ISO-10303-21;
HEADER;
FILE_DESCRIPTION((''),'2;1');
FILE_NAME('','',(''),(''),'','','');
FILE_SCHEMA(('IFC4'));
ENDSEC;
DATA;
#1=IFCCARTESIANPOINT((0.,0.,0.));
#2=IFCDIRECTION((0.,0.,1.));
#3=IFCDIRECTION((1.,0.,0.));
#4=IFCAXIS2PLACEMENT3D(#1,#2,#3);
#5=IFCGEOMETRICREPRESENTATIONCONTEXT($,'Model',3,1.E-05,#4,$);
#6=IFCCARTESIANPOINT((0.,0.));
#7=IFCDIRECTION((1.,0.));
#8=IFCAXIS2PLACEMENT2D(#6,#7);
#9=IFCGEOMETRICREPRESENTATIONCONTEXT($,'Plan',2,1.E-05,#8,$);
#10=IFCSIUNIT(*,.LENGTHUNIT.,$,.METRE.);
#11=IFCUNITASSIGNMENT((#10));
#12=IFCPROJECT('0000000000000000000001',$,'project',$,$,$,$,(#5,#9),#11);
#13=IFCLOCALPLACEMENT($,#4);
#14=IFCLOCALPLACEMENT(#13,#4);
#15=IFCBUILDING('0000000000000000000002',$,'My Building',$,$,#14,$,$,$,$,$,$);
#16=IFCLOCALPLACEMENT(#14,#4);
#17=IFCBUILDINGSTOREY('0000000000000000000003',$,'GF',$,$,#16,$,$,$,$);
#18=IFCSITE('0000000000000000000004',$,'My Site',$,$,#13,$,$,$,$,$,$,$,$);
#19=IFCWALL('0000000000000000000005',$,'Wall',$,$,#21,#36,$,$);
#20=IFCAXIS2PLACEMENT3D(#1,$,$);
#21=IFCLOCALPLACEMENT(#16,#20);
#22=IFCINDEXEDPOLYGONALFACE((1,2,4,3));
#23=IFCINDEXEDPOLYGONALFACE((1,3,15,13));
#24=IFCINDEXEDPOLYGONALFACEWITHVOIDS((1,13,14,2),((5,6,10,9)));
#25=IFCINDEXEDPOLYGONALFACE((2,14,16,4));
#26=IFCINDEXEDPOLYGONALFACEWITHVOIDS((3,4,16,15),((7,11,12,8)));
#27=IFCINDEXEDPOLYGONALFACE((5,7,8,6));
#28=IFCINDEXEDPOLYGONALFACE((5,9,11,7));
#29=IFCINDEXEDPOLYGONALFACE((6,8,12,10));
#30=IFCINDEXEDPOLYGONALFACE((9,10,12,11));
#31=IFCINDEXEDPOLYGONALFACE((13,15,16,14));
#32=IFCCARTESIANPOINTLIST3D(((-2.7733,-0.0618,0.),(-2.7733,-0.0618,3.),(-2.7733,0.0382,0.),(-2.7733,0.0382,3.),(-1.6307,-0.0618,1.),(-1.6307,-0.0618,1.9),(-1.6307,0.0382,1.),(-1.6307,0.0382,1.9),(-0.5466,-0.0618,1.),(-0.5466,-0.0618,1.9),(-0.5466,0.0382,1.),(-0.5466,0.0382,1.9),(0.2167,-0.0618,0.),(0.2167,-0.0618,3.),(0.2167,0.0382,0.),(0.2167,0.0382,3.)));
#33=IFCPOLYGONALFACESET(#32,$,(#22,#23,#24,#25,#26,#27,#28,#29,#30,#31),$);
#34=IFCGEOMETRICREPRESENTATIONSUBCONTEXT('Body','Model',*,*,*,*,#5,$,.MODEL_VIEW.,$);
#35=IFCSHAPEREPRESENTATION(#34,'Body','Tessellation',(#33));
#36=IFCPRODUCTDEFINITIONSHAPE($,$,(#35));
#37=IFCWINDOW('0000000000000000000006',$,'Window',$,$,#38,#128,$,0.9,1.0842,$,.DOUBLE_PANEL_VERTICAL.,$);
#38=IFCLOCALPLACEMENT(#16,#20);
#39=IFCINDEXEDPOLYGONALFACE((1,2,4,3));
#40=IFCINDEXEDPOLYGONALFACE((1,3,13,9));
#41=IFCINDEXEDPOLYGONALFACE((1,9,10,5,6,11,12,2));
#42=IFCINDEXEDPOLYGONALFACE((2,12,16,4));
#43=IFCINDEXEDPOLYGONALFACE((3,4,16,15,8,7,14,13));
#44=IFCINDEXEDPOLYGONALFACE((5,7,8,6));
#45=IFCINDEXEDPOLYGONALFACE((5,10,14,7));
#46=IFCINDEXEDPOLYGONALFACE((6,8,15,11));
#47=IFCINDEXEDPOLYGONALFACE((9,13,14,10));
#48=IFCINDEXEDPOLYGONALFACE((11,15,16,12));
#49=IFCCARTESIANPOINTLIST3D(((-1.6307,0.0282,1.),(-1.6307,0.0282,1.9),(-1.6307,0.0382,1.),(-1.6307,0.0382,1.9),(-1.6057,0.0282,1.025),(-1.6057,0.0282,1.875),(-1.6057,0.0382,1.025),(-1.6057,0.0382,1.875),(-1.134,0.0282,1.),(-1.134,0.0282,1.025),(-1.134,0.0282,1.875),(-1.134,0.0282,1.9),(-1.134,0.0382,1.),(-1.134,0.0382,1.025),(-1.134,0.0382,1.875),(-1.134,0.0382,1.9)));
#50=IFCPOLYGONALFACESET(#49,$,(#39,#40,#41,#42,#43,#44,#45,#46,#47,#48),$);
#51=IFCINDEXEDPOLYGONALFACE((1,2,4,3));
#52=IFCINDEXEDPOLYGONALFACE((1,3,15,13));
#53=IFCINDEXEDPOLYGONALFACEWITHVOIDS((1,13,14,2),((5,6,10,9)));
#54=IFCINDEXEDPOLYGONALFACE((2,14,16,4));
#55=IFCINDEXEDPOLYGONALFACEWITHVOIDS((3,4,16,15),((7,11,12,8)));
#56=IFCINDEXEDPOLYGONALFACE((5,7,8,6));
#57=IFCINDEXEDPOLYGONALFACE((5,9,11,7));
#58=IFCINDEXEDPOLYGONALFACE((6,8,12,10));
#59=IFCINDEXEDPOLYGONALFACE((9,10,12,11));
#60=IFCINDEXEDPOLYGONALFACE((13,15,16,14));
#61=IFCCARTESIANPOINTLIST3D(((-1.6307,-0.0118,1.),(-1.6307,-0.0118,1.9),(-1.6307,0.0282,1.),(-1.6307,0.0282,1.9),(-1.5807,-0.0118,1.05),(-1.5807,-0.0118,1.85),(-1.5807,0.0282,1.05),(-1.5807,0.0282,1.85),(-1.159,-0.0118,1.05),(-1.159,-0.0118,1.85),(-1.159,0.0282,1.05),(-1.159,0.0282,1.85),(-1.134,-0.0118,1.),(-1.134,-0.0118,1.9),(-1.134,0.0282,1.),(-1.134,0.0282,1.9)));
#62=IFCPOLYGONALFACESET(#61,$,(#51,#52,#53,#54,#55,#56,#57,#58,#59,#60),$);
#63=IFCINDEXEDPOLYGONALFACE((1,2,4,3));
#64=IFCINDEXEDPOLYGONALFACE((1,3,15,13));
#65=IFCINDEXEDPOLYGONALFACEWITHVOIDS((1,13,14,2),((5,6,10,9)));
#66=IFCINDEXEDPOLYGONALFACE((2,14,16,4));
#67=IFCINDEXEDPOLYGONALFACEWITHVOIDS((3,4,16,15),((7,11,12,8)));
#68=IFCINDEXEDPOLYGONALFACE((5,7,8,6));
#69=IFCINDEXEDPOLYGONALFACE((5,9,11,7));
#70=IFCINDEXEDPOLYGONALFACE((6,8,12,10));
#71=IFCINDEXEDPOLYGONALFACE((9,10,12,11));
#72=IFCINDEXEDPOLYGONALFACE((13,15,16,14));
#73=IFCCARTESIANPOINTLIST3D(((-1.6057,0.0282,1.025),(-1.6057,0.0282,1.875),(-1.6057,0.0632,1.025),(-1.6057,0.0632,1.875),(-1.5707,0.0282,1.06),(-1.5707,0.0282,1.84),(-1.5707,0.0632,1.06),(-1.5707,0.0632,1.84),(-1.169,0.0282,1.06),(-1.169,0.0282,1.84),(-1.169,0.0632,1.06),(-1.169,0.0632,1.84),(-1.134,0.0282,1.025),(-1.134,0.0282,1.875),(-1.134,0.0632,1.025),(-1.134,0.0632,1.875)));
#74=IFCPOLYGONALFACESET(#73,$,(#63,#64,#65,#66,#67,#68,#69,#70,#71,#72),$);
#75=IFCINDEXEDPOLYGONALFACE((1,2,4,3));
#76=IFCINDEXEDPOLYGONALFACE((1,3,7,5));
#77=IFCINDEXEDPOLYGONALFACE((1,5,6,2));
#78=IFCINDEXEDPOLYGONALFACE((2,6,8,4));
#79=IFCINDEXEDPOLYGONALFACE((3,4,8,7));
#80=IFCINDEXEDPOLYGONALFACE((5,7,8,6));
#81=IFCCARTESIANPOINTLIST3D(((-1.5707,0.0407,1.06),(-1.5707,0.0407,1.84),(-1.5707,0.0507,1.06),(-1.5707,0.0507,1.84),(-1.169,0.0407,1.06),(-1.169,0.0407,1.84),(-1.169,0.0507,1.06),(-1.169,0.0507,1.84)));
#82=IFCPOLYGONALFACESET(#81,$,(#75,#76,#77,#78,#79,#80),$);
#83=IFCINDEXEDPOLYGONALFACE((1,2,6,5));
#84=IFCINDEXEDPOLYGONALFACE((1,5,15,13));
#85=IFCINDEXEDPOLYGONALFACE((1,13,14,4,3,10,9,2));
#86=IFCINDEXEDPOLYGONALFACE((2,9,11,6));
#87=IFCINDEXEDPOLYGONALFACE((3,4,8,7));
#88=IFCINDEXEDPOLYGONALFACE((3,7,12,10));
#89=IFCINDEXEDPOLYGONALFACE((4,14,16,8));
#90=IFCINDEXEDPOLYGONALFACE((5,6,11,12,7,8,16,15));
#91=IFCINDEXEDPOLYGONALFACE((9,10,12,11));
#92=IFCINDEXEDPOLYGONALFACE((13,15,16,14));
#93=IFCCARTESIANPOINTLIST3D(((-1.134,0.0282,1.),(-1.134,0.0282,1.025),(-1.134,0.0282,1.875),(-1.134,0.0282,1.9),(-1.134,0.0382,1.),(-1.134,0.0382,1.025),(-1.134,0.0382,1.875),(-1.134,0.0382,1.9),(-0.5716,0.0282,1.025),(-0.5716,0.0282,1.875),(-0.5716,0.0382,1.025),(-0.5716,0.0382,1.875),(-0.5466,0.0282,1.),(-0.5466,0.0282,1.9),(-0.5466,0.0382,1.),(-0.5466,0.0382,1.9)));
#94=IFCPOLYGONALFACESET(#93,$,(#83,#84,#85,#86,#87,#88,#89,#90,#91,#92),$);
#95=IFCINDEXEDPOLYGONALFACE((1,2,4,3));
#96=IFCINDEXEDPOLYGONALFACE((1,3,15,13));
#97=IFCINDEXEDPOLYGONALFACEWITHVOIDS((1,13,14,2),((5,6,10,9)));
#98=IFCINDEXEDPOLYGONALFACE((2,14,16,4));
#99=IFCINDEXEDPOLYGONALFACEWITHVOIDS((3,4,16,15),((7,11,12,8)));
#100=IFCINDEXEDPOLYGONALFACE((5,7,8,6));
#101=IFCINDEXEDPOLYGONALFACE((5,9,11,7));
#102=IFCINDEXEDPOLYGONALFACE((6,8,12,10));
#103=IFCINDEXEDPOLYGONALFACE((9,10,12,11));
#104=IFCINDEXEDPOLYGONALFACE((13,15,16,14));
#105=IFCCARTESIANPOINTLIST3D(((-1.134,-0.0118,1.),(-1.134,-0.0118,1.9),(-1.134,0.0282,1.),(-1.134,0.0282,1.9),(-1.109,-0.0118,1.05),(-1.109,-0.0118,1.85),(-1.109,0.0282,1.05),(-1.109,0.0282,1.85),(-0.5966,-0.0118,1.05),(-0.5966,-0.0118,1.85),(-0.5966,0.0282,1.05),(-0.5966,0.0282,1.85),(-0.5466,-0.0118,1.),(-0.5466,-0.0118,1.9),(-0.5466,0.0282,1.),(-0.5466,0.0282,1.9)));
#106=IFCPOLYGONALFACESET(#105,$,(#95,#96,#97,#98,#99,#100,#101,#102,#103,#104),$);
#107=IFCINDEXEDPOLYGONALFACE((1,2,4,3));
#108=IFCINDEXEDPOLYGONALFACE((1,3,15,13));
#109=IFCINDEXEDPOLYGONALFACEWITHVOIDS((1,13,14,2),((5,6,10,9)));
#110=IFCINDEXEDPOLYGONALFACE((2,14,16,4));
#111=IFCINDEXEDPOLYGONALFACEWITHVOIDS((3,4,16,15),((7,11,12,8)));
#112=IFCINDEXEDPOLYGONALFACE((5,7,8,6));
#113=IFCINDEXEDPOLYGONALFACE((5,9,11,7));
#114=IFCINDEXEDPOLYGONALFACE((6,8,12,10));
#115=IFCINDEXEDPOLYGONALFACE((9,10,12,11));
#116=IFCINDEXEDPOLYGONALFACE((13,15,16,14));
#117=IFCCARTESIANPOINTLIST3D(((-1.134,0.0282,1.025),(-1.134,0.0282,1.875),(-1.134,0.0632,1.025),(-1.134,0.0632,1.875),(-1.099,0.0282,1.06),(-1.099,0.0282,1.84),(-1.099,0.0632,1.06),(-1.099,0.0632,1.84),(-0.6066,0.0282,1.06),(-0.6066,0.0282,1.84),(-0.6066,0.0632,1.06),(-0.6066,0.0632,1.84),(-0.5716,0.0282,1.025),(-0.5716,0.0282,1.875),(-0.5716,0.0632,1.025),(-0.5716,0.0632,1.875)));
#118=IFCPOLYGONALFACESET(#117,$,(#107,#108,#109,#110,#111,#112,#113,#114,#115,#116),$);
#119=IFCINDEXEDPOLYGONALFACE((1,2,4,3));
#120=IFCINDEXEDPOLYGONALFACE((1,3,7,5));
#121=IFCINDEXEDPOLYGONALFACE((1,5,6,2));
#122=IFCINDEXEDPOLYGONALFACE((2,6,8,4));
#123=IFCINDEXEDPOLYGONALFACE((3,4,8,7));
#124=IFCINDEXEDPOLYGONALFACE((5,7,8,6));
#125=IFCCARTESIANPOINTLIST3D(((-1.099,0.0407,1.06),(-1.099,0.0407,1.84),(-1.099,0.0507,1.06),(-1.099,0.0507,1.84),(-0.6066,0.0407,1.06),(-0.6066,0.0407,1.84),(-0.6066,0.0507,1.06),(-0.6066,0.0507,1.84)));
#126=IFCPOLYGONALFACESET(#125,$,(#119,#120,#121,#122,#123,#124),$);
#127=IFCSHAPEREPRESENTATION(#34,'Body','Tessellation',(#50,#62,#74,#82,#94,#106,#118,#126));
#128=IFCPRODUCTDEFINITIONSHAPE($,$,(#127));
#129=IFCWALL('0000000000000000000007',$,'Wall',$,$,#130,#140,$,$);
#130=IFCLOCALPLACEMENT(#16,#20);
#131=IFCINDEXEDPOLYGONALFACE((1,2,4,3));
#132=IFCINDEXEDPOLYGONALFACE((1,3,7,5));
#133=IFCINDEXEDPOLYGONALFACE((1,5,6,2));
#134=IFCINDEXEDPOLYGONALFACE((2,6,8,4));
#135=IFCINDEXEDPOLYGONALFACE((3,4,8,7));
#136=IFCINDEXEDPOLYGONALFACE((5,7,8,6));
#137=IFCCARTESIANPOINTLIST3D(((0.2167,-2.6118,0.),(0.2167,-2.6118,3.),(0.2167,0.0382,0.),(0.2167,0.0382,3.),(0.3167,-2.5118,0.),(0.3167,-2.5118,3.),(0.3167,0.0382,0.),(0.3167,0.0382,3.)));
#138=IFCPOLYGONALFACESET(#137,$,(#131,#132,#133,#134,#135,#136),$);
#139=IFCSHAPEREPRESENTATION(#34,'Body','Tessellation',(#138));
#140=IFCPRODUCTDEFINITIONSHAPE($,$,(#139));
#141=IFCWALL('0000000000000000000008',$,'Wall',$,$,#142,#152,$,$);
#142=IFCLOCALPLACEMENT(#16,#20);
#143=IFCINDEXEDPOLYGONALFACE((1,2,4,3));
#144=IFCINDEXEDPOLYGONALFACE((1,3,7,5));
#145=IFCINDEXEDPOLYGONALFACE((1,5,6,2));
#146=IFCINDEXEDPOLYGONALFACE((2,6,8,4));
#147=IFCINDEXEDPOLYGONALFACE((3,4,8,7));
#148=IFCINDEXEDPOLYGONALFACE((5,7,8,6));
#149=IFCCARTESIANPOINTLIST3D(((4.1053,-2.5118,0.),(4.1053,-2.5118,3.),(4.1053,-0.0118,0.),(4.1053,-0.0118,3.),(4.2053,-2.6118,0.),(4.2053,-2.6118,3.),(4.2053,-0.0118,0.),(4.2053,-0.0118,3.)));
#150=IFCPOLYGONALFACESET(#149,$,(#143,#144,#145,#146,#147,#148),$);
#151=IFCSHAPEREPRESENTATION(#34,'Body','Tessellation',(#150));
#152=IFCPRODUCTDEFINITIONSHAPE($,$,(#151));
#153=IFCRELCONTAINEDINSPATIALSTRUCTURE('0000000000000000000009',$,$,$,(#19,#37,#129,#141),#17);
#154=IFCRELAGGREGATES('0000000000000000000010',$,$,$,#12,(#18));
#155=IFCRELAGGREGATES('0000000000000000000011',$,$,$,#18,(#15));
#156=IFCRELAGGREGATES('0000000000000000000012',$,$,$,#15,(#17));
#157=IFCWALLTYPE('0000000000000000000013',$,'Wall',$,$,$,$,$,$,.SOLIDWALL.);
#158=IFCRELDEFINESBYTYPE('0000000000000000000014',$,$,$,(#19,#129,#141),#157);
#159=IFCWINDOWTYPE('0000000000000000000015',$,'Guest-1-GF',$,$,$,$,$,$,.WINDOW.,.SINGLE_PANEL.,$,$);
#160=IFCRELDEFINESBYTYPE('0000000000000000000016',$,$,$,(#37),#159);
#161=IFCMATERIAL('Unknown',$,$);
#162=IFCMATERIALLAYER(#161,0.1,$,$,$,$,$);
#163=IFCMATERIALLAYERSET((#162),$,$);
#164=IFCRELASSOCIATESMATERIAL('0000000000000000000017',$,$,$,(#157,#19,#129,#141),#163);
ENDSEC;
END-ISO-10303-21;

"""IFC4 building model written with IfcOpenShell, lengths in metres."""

from ifc_helpers import new_model, entity, si_unit, frame, origin_with_axes, origin_2d_with_axis, place, context, subcontext, project, spatial, line, indexed_curve, outline, extrude, shape, source, transform, mapped, material, layer, layer_set, layer_usage, type_object, type_shapes, element, fill, save


model = new_model("IFC4")

# Units and contexts
model_context = context("Model", 3, precision=1e-05, world=origin_with_axes())
plan_context = context("Plan", 2, precision=1e-05, world=origin_2d_with_axis())
body_context_1 = subcontext(model_context, "Body", "Model", "MODEL_VIEW")
body_context_2 = subcontext(plan_context, "Body", "Plan", "PLAN_VIEW")
ifc_project = project(units=[si_unit("LENGTHUNIT", "METRE")], contexts=[model_context, plan_context])

# Site, building, storey
site_placement = place(None, origin_with_axes())
site = spatial("IfcSite", under=ifc_project, at=site_placement, Name="My Site")
building_placement = place(site_placement, origin_with_axes())
building = spatial("IfcBuilding", under=site, at=building_placement, Name="My Building")
storey_placement = place(building_placement, origin_with_axes())
storey = spatial("IfcBuildingStorey", under=building, at=storey_placement, Name="GF")

# Shared definitions
ifc_material_1 = material(Name="Unknown")

# Wall, opening, window
ifc_layer_1 = layer(ifc_material_1, 0.1)
ifc_layer_set_1 = layer_set([ifc_layer_1])
ifc_layer_usage_1 = layer_usage(ifc_layer_set_1, "AXIS2", "POSITIVE", 0.0)
wall_type = type_object("IfcWallType", Name="Wall", PredefinedType="SOLIDWALL", material=ifc_layer_set_1)
wall_1_placement = place(storey_placement, frame((0.2167, 0.0382, 0.0), z_axis=(0.0, 0.0, 1.0), x_axis=(-1.0, 0.0, 0.0)))
wall_1 = element("IfcWall", 1, at=wall_1_placement, inside=storey, type_object=wall_type, material=ifc_layer_usage_1, Name="Wall", context=body_context_1, shape_type="SweptSolid", body=[
    extrude(outline(indexed_curve([(0.0, 0.0), (0.0, 0.1), (2.99, 0.1), (2.99, 0.0)], segments=[line(1, 2, 3, 4, 1)])), origin_with_axes(), (0.0, 0.0, 1.0), 3.0),
])
shared_shape_1 = source(origin_with_axes(), body_context_1, "Body", "SweptSolid", [
    extrude(outline(indexed_curve([(0.0, 0.0), (1.0842, 0.0), (1.0842, 0.9), (0.0, 0.9)], segments=[line(1, 2, 3, 4, 1)])), frame((0.0, -0.6, 0.0), z_axis=(0.0, -1.0, 0.0), x_axis=(1.0, 0.0, 0.0)), (0.0, 0.0, -1.0), 1.2),
])
opening_1_placement = place(wall_1_placement, frame((1.8474, 0.1, 1.0), z_axis=(0.0, 0.0, 1.0), x_axis=(-1.0, 0.0, 0.0)))
opening_1 = element("IfcOpeningElement", 2, at=opening_1_placement, cuts=wall_1, PredefinedType="OPENING", context=body_context_1, shape_type="MappedRepresentation", body=[
    mapped(shared_shape_1, transform((0.0, 0.0, 0.0), x_axis=(1.0, 0.0, 0.0), y_axis=(0.0, 1.0, 0.0), z_axis=(0.0, 0.0, 1.0), scale=1.0)),
])
window_type_1 = type_object("IfcWindowType", Name="Guest-1-GF", PartitioningType="SINGLE_PANEL", PredefinedType="WINDOW")
shared_shape_2 = source(origin_with_axes(), body_context_1, "Body", "SweptSolid", [
    extrude(outline(indexed_curve([(0.4967, 0.0), (0.0, 0.0), (0.0, 0.9), (0.4967, 0.9), (0.4967, 0.875), (0.025, 0.875), (0.025, 0.025), (0.4967, 0.025)], segments=[line(1, 2, 3, 4, 5, 6, 7, 8, 1)])), frame((0.0, 0.09, 0.0), z_axis=(0.0, -1.0, 0.0), x_axis=(1.0, 0.0, 0.0)), (0.0, 0.0, -1.0), 0.01),
    extrude(outline(indexed_curve([(0.0, 0.0), (0.4967, 0.0), (0.4967, 0.9), (0.0, 0.9)], segments=[line(1, 2, 3, 4, 1)]), holes=[indexed_curve([(0.05, 0.05), (0.4717, 0.05), (0.4717, 0.85), (0.05, 0.85)], segments=[line(1, 2, 3, 4, 1)])]), frame((0.0, 0.05, 0.0), z_axis=(0.0, -1.0, 0.0), x_axis=(1.0, 0.0, 0.0)), (0.0, 0.0, -1.0), 0.04),
    extrude(outline(indexed_curve([(0.0, 0.0), (0.4717, 0.0), (0.4717, 0.85), (0.0, 0.85)], segments=[line(1, 2, 3, 4, 1)]), holes=[indexed_curve([(0.035, 0.035), (0.4367, 0.035), (0.4367, 0.815), (0.035, 0.815)], segments=[line(1, 2, 3, 4, 1)])]), frame((0.025, 0.09, 0.025), z_axis=(0.0, -1.0, 0.0), x_axis=(1.0, 0.0, 0.0)), (0.0, 0.0, -1.0), 0.035),
    extrude(outline(indexed_curve([(0.035, 0.035), (0.4367, 0.035), (0.4367, 0.815), (0.035, 0.815)], segments=[line(1, 2, 3, 4, 1)])), frame((0.025, 0.1025, 0.025), z_axis=(0.0, -1.0, 0.0), x_axis=(1.0, 0.0, 0.0)), (0.0, 0.0, -1.0), 0.01),
    extrude(outline(indexed_curve([(0.0, 0.9), (0.5874, 0.9), (0.5874, 0.0), (0.0, 0.0), (0.0, 0.025), (0.5624, 0.025), (0.5624, 0.875), (0.0, 0.875)], segments=[line(1, 2, 3, 4, 5, 6, 7, 8, 1)])), frame((0.4967, 0.09, 0.0), z_axis=(0.0, -1.0, 0.0), x_axis=(1.0, 0.0, 0.0)), (0.0, 0.0, -1.0), 0.01),
    extrude(outline(indexed_curve([(0.0, 0.0), (0.5874, 0.0), (0.5874, 0.9), (0.0, 0.9)], segments=[line(1, 2, 3, 4, 1)]), holes=[indexed_curve([(0.025, 0.05), (0.5374, 0.05), (0.5374, 0.85), (0.025, 0.85)], segments=[line(1, 2, 3, 4, 1)])]), frame((0.4967, 0.05, 0.0), z_axis=(0.0, -1.0, 0.0), x_axis=(1.0, 0.0, 0.0)), (0.0, 0.0, -1.0), 0.04),
    extrude(outline(indexed_curve([(0.0, 0.0), (0.5624, 0.0), (0.5624, 0.85), (0.0, 0.85)], segments=[line(1, 2, 3, 4, 1)]), holes=[indexed_curve([(0.035, 0.035), (0.5274, 0.035), (0.5274, 0.815), (0.035, 0.815)], segments=[line(1, 2, 3, 4, 1)])]), frame((0.4967, 0.09, 0.025), z_axis=(0.0, -1.0, 0.0), x_axis=(1.0, 0.0, 0.0)), (0.0, 0.0, -1.0), 0.035),
    extrude(outline(indexed_curve([(0.035, 0.035), (0.5274, 0.035), (0.5274, 0.815), (0.035, 0.815)], segments=[line(1, 2, 3, 4, 1)])), frame((0.4967, 0.1025, 0.025), z_axis=(0.0, -1.0, 0.0), x_axis=(1.0, 0.0, 0.0)), (0.0, 0.0, -1.0), 0.01),
])
shared_shape_3 = source(origin_with_axes(), body_context_2, "Body", "Curve2D", [
    entity("IfcIndexedPolyCurve", entity("IfcCartesianPointList2D", [[0.05, 0.05], [0.4717, 0.05]])),
    entity("IfcIndexedPolyCurve", entity("IfcCartesianPointList2D", [[0.0, 0.1], [0.025, 0.1], [0.025, 0.09], [0.05, 0.09], [0.05, 0.05], [0.0, 0.05]]), [entity("IfcLineIndex", [1, 2, 3, 4, 5, 6, 1])]),
    entity("IfcIndexedPolyCurve", entity("IfcCartesianPointList2D", [[0.4967, 0.1], [0.4967, 0.1], [0.4967, 0.09], [0.4717, 0.09], [0.4717, 0.05], [0.4967, 0.05]])),
    entity("IfcIndexedPolyCurve", entity("IfcCartesianPointList2D", [[0.025, 0.09], [0.06, 0.09], [0.06, 0.125], [0.025, 0.125]]), [entity("IfcLineIndex", [1, 2, 3, 4, 1])]),
    entity("IfcIndexedPolyCurve", entity("IfcCartesianPointList2D", [[0.4967, 0.09], [0.4617, 0.09], [0.4617, 0.125], [0.4967, 0.125]]), [entity("IfcLineIndex", [1, 2, 3, 4, 1])]),
    entity("IfcIndexedPolyCurve", entity("IfcCartesianPointList2D", [[0.06, 0.09], [0.4617, 0.09]])),
    entity("IfcIndexedPolyCurve", entity("IfcCartesianPointList2D", [[0.06, 0.125], [0.4617, 0.125]])),
    entity("IfcIndexedPolyCurve", entity("IfcCartesianPointList2D", [[0.06, 0.1075], [0.4617, 0.1075]])),
    entity("IfcIndexedPolyCurve", entity("IfcCartesianPointList2D", [[0.5217, 0.05], [1.0342, 0.05]])),
    entity("IfcIndexedPolyCurve", entity("IfcCartesianPointList2D", [[0.4967, 0.1], [0.4967, 0.1], [0.4967, 0.09], [0.5217, 0.09], [0.5217, 0.05], [0.4967, 0.05]])),
    entity("IfcIndexedPolyCurve", entity("IfcCartesianPointList2D", [[1.0842, 0.1], [1.0592, 0.1], [1.0592, 0.09], [1.0342, 0.09], [1.0342, 0.05], [1.0842, 0.05]]), [entity("IfcLineIndex", [1, 2, 3, 4, 5, 6, 1])]),
    entity("IfcIndexedPolyCurve", entity("IfcCartesianPointList2D", [[0.4967, 0.09], [0.5317, 0.09], [0.5317, 0.125], [0.4967, 0.125]]), [entity("IfcLineIndex", [1, 2, 3, 4, 1])]),
    entity("IfcIndexedPolyCurve", entity("IfcCartesianPointList2D", [[1.0592, 0.09], [1.0242, 0.09], [1.0242, 0.125], [1.0592, 0.125]]), [entity("IfcLineIndex", [1, 2, 3, 4, 1])]),
    entity("IfcIndexedPolyCurve", entity("IfcCartesianPointList2D", [[0.5317, 0.09], [1.0242, 0.09]])),
    entity("IfcIndexedPolyCurve", entity("IfcCartesianPointList2D", [[0.5317, 0.125], [1.0242, 0.125]])),
    entity("IfcIndexedPolyCurve", entity("IfcCartesianPointList2D", [[0.5317, 0.1075], [1.0242, 0.1075]])),
])
type_shapes(window_type_1, [shared_shape_2, shared_shape_3])
window_1_placement = place(opening_1_placement, frame((0.0, 0.0, 0.0), z_axis=(0.0, 0.0, 1.0), x_axis=(1.0, 0.0, 0.0)))
window_1 = element("IfcWindow", 3, at=window_1_placement, inside=storey, type_object=window_type_1, Name="Window", OverallHeight=0.9, OverallWidth=1.0842, PartitioningType="DOUBLE_PANEL_VERTICAL", shapes=[
    shape(body_context_1, "Body", "MappedRepresentation", [mapped(shared_shape_2, transform((0.0, 0.0, 0.0), x_axis=(1.0, 0.0, 0.0), y_axis=(0.0, 1.0, 0.0), z_axis=(0.0, 0.0, 1.0), scale=1.0))]),
    shape(body_context_2, "Body", "MappedRepresentation", [mapped(shared_shape_3, transform((0.0, 0.0, 0.0), x_axis=(1.0, 0.0, 0.0), y_axis=(0.0, 1.0, 0.0), z_axis=(0.0, 0.0, 1.0), scale=1.0))]),
])
fill(opening_1, window_1)

# Wall
ifc_layer_usage_2 = layer_usage(ifc_layer_set_1, "AXIS2", "POSITIVE", 0.0)
wall_2_placement = place(storey_placement, frame((0.2167, 0.0382, 0.0), z_axis=(0.0, 0.0, 1.0), x_axis=(0.0, -1.0, 0.0)))
element("IfcWall", 4, at=wall_2_placement, inside=storey, type_object=wall_type, material=ifc_layer_usage_2, Name="Wall", context=body_context_1, shape_type="SweptSolid", body=[
    extrude(outline(indexed_curve([(0.0, 0.0), (0.0, 0.1), (2.55, 0.1), (2.65, 0.0)], segments=[line(1, 2, 3, 4, 1)])), origin_with_axes(), (0.0, 0.0, 1.0), 3.0),
])

# Wall
ifc_layer_usage_3 = layer_usage(ifc_layer_set_1, "AXIS2", "POSITIVE", 0.0)
wall_3_placement = place(storey_placement, frame((4.2053, -2.6118, 0.0), z_axis=(0.0, 0.0, 1.0), x_axis=(0.0, 1.0, 0.0)))
element("IfcWall", 5, at=wall_3_placement, inside=storey, type_object=wall_type, material=ifc_layer_usage_3, Name="Wall", context=body_context_1, shape_type="SweptSolid", body=[
    extrude(outline(indexed_curve([(0.0, 0.0), (0.1, 0.1), (2.6, 0.1), (2.6, 0.0)], segments=[line(1, 2, 3, 4, 1)])), origin_with_axes(), (0.0, 0.0, 1.0), 3.0),
])

save(model, "model.ifc")
